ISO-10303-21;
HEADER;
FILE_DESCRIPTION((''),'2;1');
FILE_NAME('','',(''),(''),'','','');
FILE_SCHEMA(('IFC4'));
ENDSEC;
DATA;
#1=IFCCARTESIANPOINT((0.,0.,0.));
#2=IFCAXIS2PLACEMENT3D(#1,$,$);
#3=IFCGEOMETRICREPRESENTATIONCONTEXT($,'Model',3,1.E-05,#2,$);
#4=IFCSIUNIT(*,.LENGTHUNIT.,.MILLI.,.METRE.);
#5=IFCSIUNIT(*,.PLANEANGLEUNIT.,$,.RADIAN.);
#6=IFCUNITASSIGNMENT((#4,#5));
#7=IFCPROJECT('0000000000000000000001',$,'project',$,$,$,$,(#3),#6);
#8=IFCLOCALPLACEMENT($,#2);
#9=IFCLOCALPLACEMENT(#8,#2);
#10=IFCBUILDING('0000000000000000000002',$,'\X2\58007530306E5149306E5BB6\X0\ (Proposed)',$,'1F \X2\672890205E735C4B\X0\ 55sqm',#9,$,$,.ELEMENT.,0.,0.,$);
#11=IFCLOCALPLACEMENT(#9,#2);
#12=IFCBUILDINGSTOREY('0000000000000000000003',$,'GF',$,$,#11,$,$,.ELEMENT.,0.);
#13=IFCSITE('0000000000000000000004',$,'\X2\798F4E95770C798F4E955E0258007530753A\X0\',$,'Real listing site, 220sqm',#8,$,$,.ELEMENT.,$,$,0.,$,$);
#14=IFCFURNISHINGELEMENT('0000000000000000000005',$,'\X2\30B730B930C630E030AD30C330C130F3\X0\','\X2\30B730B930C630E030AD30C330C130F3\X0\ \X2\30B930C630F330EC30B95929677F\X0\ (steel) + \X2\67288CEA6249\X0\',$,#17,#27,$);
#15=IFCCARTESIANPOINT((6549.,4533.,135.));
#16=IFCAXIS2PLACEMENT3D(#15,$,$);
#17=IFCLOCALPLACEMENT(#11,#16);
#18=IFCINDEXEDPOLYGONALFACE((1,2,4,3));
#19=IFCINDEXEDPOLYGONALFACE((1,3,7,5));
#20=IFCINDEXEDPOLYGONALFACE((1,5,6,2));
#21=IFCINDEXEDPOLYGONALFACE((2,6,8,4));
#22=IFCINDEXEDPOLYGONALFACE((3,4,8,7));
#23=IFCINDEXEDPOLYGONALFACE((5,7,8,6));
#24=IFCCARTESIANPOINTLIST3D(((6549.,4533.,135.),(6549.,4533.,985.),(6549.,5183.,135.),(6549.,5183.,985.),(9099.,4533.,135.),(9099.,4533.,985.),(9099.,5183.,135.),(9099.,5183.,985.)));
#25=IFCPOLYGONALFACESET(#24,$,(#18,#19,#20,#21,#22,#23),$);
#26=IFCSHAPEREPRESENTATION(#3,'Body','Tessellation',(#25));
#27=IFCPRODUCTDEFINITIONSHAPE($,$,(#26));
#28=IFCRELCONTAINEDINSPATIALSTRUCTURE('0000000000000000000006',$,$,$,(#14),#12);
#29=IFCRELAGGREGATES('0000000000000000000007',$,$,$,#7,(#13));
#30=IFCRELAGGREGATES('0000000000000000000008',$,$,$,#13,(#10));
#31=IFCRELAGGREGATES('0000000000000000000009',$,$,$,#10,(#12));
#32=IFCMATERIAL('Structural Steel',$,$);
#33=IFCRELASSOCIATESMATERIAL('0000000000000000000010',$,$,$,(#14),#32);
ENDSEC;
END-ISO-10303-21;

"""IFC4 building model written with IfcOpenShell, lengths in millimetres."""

from ifc_helpers import new_model, si_unit, frame, frame_2d, origin, place, context, project, spatial, rectangle, extrude, material, element, save


model = new_model("IFC4")

# Units and contexts
model_context = context("Model", 3, precision=1e-05, world=origin())
ifc_project = project(units=[si_unit("LENGTHUNIT", "METRE", prefix="MILLI"), si_unit("PLANEANGLEUNIT", "RADIAN")], contexts=[model_context])

# Site, building, storey
site_placement = place(None, origin())
site = spatial("IfcSite", under=ifc_project, at=site_placement, Name="福井県福井市堀田町", ObjectType="Real listing site, 220sqm", CompositionType="ELEMENT", RefElevation=0.0)
building_placement = place(site_placement, origin())
building = spatial("IfcBuilding", under=site, at=building_placement, Name="堀田の光の家 (Proposed)", ObjectType="1F 木造平屋 55sqm", CompositionType="ELEMENT", ElevationOfRefHeight=0.0, ElevationOfTerrain=0.0)
storey_placement = place(building_placement, origin())
storey = spatial("IfcBuildingStorey", under=building, at=storey_placement, Name="GF", CompositionType="ELEMENT", Elevation=0.0)

# Shared definitions
ifc_material_1 = material(Name="Structural Steel")

# Furnishing element
furnishing_1_placement = place(storey_placement, frame((6549.0, 4533.0, 135.0)))
element("IfcFurnishingElement", 1, at=furnishing_1_placement, inside=storey, material=ifc_material_1, Name="システムキッチン", Description="システムキッチン ステンレス天板 (steel) + 木質扉", context=model_context, shape_type="SweptSolid", body=[
    extrude(rectangle(XDim=2550.0, YDim=650.0, at=frame_2d((1275.0, 325.0))), frame((6549.0, 4533.0, 135.0)), (0.0, 0.0, 1.0), 850.0),
])

save(model, "model.ifc")
